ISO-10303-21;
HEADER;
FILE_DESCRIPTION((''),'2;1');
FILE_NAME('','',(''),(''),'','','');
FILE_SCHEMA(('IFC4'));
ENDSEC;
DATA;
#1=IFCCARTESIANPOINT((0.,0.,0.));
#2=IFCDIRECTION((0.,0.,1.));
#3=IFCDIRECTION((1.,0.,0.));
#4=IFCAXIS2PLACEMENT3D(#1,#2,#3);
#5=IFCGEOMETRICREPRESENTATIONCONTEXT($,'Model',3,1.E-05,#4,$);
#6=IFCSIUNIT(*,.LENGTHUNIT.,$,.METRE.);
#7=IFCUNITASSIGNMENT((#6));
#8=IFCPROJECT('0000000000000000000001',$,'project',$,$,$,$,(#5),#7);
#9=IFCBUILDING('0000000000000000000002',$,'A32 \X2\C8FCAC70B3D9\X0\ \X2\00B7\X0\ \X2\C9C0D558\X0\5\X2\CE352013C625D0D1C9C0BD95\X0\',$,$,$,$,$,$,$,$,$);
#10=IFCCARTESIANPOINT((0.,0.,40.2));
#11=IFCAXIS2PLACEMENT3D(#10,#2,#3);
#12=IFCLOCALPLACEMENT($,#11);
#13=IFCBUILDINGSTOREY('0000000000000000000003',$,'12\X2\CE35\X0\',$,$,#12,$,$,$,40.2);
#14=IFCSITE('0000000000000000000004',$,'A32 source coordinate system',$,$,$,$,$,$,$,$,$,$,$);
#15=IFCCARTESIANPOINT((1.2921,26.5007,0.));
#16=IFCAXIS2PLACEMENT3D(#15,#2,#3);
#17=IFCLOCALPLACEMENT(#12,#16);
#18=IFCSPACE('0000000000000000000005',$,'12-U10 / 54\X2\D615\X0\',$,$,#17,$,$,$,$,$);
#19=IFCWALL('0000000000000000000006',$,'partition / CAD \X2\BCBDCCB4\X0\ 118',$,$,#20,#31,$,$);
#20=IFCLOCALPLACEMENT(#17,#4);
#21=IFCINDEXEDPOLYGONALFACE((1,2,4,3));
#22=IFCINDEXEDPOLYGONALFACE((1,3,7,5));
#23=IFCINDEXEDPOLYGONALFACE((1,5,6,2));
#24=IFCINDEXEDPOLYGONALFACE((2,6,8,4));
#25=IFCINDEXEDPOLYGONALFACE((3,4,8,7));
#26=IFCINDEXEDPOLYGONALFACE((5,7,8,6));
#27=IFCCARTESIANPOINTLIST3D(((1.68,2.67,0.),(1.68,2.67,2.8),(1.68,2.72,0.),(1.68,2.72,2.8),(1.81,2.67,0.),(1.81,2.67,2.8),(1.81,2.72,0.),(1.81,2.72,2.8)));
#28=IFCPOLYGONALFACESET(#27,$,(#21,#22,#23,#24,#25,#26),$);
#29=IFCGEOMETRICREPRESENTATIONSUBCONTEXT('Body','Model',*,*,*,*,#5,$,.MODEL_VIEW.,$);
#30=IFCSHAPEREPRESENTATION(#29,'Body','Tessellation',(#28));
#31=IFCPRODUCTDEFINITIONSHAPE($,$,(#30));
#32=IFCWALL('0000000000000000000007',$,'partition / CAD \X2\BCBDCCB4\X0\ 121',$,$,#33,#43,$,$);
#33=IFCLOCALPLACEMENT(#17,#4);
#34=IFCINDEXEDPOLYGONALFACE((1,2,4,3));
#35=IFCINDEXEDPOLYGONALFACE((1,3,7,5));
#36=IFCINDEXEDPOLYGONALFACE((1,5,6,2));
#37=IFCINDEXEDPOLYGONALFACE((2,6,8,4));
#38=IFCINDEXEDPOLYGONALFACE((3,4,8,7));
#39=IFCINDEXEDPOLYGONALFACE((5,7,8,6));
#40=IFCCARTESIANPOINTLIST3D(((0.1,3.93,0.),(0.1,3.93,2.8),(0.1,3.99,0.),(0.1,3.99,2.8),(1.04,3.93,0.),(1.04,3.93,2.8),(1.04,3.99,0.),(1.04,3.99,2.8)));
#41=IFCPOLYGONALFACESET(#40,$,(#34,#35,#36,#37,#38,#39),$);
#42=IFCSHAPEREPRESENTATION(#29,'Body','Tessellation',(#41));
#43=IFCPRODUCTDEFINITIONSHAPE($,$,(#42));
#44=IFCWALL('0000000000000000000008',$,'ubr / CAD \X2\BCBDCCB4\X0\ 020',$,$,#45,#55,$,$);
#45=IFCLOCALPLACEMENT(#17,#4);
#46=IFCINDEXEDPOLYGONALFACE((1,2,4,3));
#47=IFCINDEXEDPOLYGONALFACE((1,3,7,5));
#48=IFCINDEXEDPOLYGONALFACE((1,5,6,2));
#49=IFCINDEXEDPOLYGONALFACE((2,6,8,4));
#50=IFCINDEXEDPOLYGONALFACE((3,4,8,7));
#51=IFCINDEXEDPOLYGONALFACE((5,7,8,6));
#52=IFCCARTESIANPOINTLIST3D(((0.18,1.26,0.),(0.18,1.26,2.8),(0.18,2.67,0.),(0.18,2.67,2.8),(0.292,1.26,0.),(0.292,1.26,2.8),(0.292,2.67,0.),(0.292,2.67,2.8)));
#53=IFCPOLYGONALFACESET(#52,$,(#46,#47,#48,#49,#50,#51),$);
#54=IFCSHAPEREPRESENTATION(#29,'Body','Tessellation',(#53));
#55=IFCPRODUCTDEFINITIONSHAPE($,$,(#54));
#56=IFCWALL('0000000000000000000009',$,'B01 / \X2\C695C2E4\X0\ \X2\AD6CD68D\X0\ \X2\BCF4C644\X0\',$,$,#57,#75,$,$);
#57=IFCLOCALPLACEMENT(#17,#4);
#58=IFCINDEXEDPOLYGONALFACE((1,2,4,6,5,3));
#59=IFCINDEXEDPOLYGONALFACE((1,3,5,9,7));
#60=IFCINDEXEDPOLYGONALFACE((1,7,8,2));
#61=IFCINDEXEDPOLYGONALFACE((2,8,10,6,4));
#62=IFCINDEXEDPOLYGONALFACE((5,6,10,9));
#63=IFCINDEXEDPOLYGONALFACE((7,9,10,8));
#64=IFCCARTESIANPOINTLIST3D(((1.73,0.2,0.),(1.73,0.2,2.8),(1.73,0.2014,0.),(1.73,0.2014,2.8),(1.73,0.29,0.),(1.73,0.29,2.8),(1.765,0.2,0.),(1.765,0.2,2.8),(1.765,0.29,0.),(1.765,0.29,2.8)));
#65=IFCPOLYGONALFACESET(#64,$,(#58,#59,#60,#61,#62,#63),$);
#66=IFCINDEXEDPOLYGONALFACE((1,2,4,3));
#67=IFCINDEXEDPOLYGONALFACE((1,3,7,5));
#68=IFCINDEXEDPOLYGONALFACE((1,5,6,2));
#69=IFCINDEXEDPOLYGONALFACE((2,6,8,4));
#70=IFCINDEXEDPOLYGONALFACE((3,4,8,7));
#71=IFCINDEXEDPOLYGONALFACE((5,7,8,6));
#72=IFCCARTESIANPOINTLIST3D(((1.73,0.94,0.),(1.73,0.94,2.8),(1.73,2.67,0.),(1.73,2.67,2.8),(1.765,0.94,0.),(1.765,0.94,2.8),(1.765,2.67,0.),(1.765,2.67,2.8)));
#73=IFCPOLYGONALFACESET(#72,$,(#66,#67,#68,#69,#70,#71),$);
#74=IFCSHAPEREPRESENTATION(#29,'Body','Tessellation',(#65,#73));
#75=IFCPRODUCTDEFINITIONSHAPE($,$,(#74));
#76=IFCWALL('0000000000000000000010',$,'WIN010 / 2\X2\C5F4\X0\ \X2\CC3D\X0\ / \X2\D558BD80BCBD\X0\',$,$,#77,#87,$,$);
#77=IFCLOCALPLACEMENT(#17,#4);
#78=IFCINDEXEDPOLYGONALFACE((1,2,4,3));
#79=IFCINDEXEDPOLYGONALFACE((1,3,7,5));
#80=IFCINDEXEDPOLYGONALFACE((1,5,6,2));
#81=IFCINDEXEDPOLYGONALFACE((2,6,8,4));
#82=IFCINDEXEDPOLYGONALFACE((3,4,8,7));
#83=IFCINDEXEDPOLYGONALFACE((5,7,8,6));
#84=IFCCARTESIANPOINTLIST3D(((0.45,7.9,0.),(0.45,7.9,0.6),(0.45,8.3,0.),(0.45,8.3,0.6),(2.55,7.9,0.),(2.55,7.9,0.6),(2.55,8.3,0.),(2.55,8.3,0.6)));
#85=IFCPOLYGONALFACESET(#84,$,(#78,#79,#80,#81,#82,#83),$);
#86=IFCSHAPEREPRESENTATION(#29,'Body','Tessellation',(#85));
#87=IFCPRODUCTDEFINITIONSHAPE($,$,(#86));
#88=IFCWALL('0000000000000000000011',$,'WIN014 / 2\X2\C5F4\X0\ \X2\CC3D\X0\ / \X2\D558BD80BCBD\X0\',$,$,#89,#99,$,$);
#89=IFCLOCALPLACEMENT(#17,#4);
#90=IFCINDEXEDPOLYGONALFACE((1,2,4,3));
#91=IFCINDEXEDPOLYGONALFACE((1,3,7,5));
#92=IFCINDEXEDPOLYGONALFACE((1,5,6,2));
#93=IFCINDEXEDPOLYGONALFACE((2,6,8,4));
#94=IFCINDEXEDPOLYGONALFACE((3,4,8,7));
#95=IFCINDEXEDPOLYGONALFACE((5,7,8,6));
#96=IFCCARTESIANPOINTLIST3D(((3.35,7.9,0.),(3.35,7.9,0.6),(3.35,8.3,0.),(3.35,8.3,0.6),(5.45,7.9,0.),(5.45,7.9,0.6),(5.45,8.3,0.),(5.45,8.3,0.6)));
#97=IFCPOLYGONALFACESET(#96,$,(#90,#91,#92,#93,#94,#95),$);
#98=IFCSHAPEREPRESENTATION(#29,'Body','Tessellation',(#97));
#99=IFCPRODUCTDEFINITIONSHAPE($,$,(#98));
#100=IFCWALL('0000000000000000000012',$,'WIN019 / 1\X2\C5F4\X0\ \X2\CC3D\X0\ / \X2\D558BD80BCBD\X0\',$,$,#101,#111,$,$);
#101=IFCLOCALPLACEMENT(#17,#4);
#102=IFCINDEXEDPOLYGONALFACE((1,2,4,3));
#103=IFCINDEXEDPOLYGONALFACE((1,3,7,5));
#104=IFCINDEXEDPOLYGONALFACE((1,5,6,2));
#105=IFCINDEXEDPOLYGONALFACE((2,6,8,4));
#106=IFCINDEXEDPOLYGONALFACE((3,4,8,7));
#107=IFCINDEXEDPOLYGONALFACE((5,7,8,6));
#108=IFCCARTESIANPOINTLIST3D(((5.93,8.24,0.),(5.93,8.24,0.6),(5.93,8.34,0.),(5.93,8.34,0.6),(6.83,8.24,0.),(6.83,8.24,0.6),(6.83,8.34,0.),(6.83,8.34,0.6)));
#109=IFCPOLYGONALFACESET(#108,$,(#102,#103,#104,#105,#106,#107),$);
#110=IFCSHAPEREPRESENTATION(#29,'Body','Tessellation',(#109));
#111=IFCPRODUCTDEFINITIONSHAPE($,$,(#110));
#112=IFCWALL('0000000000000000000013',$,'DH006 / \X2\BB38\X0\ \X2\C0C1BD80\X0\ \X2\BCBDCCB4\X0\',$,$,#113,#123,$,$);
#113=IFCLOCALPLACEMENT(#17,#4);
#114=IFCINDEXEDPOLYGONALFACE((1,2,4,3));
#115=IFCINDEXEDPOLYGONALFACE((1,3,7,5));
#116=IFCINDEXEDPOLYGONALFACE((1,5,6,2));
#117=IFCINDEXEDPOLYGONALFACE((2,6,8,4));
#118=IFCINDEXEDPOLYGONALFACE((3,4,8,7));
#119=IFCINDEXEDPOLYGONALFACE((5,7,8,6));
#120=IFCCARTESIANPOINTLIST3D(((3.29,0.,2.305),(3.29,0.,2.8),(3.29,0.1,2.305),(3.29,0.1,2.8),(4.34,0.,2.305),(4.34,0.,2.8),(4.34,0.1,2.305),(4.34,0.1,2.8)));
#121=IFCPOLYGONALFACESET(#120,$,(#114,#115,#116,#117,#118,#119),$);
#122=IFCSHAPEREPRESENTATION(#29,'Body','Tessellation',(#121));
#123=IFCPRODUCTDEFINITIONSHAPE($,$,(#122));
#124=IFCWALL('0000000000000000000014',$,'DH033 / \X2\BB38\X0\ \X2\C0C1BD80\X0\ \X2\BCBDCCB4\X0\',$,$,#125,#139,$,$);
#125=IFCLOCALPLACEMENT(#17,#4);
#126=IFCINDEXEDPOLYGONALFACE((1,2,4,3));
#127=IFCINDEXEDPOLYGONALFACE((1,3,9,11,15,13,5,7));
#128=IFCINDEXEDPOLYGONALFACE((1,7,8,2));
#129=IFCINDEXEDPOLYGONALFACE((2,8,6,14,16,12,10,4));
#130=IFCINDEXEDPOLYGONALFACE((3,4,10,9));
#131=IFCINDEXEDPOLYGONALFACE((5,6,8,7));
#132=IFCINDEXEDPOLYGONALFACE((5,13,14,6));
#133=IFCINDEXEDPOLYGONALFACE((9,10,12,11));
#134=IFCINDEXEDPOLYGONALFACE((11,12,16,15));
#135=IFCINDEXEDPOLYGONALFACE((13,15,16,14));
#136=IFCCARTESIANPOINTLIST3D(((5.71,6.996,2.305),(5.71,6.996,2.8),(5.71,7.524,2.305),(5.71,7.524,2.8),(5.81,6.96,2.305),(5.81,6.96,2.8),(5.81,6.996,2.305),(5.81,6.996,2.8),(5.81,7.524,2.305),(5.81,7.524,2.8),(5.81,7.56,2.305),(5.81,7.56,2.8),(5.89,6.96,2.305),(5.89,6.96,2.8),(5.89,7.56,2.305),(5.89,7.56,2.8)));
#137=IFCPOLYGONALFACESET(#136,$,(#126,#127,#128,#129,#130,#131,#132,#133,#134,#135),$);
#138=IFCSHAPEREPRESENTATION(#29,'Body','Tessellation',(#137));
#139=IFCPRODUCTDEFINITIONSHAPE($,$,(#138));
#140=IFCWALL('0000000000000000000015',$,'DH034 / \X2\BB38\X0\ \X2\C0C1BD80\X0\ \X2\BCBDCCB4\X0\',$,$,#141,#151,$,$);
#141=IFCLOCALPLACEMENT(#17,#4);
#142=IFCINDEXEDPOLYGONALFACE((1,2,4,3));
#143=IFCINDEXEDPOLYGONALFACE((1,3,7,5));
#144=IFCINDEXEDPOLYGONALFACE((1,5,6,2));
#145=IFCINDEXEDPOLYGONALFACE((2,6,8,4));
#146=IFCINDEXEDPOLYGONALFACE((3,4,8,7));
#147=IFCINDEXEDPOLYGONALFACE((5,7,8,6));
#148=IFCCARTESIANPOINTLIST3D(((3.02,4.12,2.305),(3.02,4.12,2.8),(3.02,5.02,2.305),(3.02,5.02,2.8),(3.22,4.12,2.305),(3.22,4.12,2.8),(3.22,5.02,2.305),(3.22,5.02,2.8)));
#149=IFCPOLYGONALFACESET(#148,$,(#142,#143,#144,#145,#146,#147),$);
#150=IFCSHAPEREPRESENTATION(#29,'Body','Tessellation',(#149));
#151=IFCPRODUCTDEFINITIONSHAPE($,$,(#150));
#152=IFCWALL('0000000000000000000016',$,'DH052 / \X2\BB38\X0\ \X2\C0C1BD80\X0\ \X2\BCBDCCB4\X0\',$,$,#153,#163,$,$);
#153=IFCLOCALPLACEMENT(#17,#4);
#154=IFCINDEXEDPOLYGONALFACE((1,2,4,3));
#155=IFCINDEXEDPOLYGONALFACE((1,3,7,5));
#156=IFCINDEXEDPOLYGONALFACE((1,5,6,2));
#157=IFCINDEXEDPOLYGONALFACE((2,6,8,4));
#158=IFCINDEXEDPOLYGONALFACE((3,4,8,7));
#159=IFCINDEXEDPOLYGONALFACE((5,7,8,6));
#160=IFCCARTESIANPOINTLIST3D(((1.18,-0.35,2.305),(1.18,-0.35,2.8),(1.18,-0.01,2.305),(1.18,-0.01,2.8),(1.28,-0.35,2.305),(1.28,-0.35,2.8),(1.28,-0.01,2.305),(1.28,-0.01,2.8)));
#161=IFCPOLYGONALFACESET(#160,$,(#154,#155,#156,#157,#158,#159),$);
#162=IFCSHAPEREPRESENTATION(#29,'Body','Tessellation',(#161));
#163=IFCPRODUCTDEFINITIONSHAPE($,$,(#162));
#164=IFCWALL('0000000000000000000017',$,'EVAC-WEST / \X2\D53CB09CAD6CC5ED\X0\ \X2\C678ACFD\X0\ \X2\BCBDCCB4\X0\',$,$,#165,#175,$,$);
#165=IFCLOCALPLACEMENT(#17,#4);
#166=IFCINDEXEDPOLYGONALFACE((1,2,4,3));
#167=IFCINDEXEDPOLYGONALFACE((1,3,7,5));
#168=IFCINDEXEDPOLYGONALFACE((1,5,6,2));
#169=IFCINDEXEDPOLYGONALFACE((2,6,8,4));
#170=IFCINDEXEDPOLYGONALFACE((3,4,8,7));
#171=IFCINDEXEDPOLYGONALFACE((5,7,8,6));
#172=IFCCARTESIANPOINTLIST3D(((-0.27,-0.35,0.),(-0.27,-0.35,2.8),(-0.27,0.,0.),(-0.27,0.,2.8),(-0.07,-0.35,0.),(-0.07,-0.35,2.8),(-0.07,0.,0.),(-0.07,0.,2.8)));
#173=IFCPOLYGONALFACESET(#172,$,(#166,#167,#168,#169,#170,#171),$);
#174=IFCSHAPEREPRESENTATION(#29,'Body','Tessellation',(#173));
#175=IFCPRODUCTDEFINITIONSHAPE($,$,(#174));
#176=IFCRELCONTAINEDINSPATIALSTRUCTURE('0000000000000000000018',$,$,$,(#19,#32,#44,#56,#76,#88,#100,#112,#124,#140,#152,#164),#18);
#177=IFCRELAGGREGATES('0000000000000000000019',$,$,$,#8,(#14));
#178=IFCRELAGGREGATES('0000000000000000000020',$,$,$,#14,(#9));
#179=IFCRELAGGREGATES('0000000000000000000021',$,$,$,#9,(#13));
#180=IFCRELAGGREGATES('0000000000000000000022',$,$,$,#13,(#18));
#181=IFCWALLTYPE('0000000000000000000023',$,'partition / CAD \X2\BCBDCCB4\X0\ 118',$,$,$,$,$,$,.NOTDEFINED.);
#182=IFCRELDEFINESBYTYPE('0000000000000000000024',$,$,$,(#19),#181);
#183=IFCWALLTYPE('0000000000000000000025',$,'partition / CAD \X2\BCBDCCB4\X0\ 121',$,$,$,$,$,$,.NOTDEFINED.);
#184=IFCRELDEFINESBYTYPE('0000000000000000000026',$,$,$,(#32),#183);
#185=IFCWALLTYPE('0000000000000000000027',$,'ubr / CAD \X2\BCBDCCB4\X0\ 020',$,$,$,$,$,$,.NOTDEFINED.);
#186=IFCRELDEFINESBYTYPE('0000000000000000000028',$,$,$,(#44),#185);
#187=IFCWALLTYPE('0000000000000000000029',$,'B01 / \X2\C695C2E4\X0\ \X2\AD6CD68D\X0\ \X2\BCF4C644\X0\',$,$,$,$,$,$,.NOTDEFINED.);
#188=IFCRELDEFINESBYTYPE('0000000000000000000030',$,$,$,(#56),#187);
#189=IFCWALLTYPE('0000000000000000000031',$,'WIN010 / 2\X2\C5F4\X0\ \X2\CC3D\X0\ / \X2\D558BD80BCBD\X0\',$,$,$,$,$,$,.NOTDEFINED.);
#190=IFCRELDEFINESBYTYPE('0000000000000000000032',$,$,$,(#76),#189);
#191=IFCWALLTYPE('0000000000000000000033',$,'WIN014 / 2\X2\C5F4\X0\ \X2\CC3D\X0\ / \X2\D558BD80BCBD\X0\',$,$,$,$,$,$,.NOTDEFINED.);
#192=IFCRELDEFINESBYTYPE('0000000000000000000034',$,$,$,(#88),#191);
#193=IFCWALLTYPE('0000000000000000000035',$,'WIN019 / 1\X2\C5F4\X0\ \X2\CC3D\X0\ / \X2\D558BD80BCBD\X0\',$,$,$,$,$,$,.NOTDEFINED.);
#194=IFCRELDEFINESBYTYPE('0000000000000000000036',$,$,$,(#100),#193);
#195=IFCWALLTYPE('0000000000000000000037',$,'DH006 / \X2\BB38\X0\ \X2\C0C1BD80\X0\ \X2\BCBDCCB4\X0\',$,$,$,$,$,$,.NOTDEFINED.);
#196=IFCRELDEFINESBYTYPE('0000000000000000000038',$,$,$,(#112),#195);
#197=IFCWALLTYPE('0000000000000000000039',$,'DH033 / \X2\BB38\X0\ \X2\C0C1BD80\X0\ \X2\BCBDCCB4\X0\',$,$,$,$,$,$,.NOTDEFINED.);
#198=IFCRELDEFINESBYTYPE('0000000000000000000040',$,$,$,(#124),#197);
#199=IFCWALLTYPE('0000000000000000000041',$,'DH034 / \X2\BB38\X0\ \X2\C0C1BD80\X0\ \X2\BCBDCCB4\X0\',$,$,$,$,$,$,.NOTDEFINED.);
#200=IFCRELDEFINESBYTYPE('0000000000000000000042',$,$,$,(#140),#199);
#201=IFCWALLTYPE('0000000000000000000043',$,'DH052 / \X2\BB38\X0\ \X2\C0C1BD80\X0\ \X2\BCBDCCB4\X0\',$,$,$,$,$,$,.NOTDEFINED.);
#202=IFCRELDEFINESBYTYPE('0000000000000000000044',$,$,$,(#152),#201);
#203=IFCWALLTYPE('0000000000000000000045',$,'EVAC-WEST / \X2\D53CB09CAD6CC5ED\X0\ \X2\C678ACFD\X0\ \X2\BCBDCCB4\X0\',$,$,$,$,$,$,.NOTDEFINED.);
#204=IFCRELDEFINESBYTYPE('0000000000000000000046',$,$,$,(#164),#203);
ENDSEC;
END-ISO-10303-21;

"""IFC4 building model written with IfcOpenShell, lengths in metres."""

from ifc_helpers import new_model, si_unit, frame, origin, origin_with_axes, place, context, subcontext, project, spatial, polyline, outline, extrude, source, transform, mapped, type_object, type_shapes, element, save


model = new_model("IFC4")

# Units and contexts
model_context = context("Model", 3, precision=1e-05, world=origin_with_axes())
body_context = subcontext(model_context, "Body", "Model", "MODEL_VIEW")
ifc_project = project(units=[si_unit("LENGTHUNIT", "METRE")], contexts=[model_context])

# Site, building, storey, space
site = spatial("IfcSite", under=ifc_project, Name="A32 source coordinate system")
building = spatial("IfcBuilding", under=site, Name="A32 주거동 · 지하5층–옥탑지붕")
storey_placement = place(None, frame((0.0, 0.0, 40.2), z_axis=(0.0, 0.0, 1.0), x_axis=(1.0, 0.0, 0.0)))
storey = spatial("IfcBuildingStorey", under=building, at=storey_placement, Name="12층", Elevation=40.2)
space_placement = place(storey_placement, frame((1.2921, 26.5007, 0.0), z_axis=(0.0, 0.0, 1.0), x_axis=(1.0, 0.0, 0.0)))
space = spatial("IfcSpace", under=storey, at=space_placement, Name="12-U10 / 54형")

# Walls
wall_type_1 = type_object("IfcWallType", Name="partition / CAD 벽체 118", PredefinedType="NOTDEFINED")
shared_shape_1 = source(origin(), body_context, "Body", "SweptSolid", [
    extrude(outline(polyline([(1.81, 2.67), (1.68, 2.67), (1.68, 2.72), (1.81, 2.72), (1.81, 2.67)])), origin(), (0.0, 0.0, 1.0), 2.8),
])
type_shapes(wall_type_1, [shared_shape_1])
wall_1_placement = place(space_placement, origin_with_axes())
element("IfcWall", 1, at=wall_1_placement, inside=space, type_object=wall_type_1, Name="partition / CAD 벽체 118", context=body_context, shape_type="MappedRepresentation", body=[
    mapped(shared_shape_1, transform((0.0, 0.0, 0.0), scale=1.0)),
])
wall_type_2 = type_object("IfcWallType", Name="partition / CAD 벽체 121", PredefinedType="NOTDEFINED")
shared_shape_2 = source(origin(), body_context, "Body", "SweptSolid", [
    extrude(outline(polyline([(0.1, 3.99), (1.04, 3.99), (1.04, 3.93), (0.1, 3.93), (0.1, 3.99)])), origin(), (0.0, 0.0, 1.0), 2.8),
])
type_shapes(wall_type_2, [shared_shape_2])
wall_2_placement = place(space_placement, origin_with_axes())
element("IfcWall", 2, at=wall_2_placement, inside=space, type_object=wall_type_2, Name="partition / CAD 벽체 121", context=body_context, shape_type="MappedRepresentation", body=[
    mapped(shared_shape_2, transform((0.0, 0.0, 0.0), scale=1.0)),
])
wall_type_3 = type_object("IfcWallType", Name="ubr / CAD 벽체 020", PredefinedType="NOTDEFINED")
shared_shape_3 = source(origin(), body_context, "Body", "SweptSolid", [
    extrude(outline(polyline([(0.18, 1.26), (0.18, 2.67), (0.292, 2.67), (0.292, 1.26), (0.18, 1.26)])), origin(), (0.0, 0.0, 1.0), 2.8),
])
type_shapes(wall_type_3, [shared_shape_3])
wall_3_placement = place(space_placement, origin_with_axes())
element("IfcWall", 3, at=wall_3_placement, inside=space, type_object=wall_type_3, Name="ubr / CAD 벽체 020", context=body_context, shape_type="MappedRepresentation", body=[
    mapped(shared_shape_3, transform((0.0, 0.0, 0.0), scale=1.0)),
])
wall_type_4 = type_object("IfcWallType", Name="B01 / 욕실 구획 보완", PredefinedType="NOTDEFINED")
shared_shape_4 = source(origin(), body_context, "Body", "SweptSolid", [
    extrude(outline(polyline([(1.765, 0.2), (1.73, 0.2), (1.73, 0.2014), (1.73, 0.29), (1.765, 0.29), (1.765, 0.2)])), origin(), (0.0, 0.0, 1.0), 2.8),
    extrude(outline(polyline([(1.765, 2.67), (1.765, 0.94), (1.73, 0.94), (1.73, 2.67), (1.765, 2.67)])), origin(), (0.0, 0.0, 1.0), 2.8),
])
type_shapes(wall_type_4, [shared_shape_4])
wall_4_placement = place(space_placement, origin_with_axes())
element("IfcWall", 4, at=wall_4_placement, inside=space, type_object=wall_type_4, Name="B01 / 욕실 구획 보완", context=body_context, shape_type="MappedRepresentation", body=[
    mapped(shared_shape_4, transform((0.0, 0.0, 0.0), scale=1.0)),
])
wall_type_5 = type_object("IfcWallType", Name="WIN010 / 2열 창 / 하부벽", PredefinedType="NOTDEFINED")
shared_shape_5 = source(origin(), body_context, "Body", "SweptSolid", [
    extrude(outline(polyline([(2.55, 8.3), (2.55, 7.9), (0.45, 7.9), (0.45, 8.3), (2.55, 8.3)])), origin(), (0.0, 0.0, 1.0), 0.6),
])
type_shapes(wall_type_5, [shared_shape_5])
wall_5_placement = place(space_placement, origin_with_axes())
element("IfcWall", 5, at=wall_5_placement, inside=space, type_object=wall_type_5, Name="WIN010 / 2열 창 / 하부벽", context=body_context, shape_type="MappedRepresentation", body=[
    mapped(shared_shape_5, transform((0.0, 0.0, 0.0), scale=1.0)),
])
wall_type_6 = type_object("IfcWallType", Name="WIN014 / 2열 창 / 하부벽", PredefinedType="NOTDEFINED")
shared_shape_6 = source(origin(), body_context, "Body", "SweptSolid", [
    extrude(outline(polyline([(5.45, 8.3), (5.45, 7.9), (3.35, 7.9), (3.35, 8.3), (5.45, 8.3)])), origin(), (0.0, 0.0, 1.0), 0.6),
])
type_shapes(wall_type_6, [shared_shape_6])
wall_6_placement = place(space_placement, origin_with_axes())
element("IfcWall", 6, at=wall_6_placement, inside=space, type_object=wall_type_6, Name="WIN014 / 2열 창 / 하부벽", context=body_context, shape_type="MappedRepresentation", body=[
    mapped(shared_shape_6, transform((0.0, 0.0, 0.0), scale=1.0)),
])
wall_type_7 = type_object("IfcWallType", Name="WIN019 / 1열 창 / 하부벽", PredefinedType="NOTDEFINED")
shared_shape_7 = source(origin(), body_context, "Body", "SweptSolid", [
    extrude(outline(polyline([(6.83, 8.34), (6.83, 8.24), (5.93, 8.24), (5.93, 8.34), (6.83, 8.34)])), origin(), (0.0, 0.0, 1.0), 0.6),
])
type_shapes(wall_type_7, [shared_shape_7])
wall_7_placement = place(space_placement, origin_with_axes())
element("IfcWall", 7, at=wall_7_placement, inside=space, type_object=wall_type_7, Name="WIN019 / 1열 창 / 하부벽", context=body_context, shape_type="MappedRepresentation", body=[
    mapped(shared_shape_7, transform((0.0, 0.0, 0.0), scale=1.0)),
])
wall_type_8 = type_object("IfcWallType", Name="DH006 / 문 상부 벽체", PredefinedType="NOTDEFINED")
shared_shape_8 = source(origin(), body_context, "Body", "SweptSolid", [
    extrude(outline(polyline([(4.34, 0.0), (3.29, 0.0), (3.29, 0.1), (4.34, 0.1), (4.34, 0.0)])), frame((0.0, 0.0, 2.305)), (0.0, 0.0, 1.0), 0.495),
])
type_shapes(wall_type_8, [shared_shape_8])
wall_8_placement = place(space_placement, origin_with_axes())
element("IfcWall", 8, at=wall_8_placement, inside=space, type_object=wall_type_8, Name="DH006 / 문 상부 벽체", context=body_context, shape_type="MappedRepresentation", body=[
    mapped(shared_shape_8, transform((0.0, 0.0, 0.0), scale=1.0)),
])
wall_type_9 = type_object("IfcWallType", Name="DH033 / 문 상부 벽체", PredefinedType="NOTDEFINED")
shared_shape_9 = source(origin(), body_context, "Body", "SweptSolid", [
    extrude(outline(polyline([(5.81, 6.996), (5.71, 6.996), (5.71, 7.524), (5.81, 7.524), (5.81, 7.56), (5.89, 7.56), (5.89, 6.96), (5.81, 6.96), (5.81, 6.996)])), frame((0.0, 0.0, 2.305)), (0.0, 0.0, 1.0), 0.495),
])
type_shapes(wall_type_9, [shared_shape_9])
wall_9_placement = place(space_placement, origin_with_axes())
element("IfcWall", 9, at=wall_9_placement, inside=space, type_object=wall_type_9, Name="DH033 / 문 상부 벽체", context=body_context, shape_type="MappedRepresentation", body=[
    mapped(shared_shape_9, transform((0.0, 0.0, 0.0), scale=1.0)),
])
wall_type_10 = type_object("IfcWallType", Name="DH034 / 문 상부 벽체", PredefinedType="NOTDEFINED")
shared_shape_10 = source(origin(), body_context, "Body", "SweptSolid", [
    extrude(outline(polyline([(3.22, 4.12), (3.02, 4.12), (3.02, 5.02), (3.22, 5.02), (3.22, 4.12)])), frame((0.0, 0.0, 2.305)), (0.0, 0.0, 1.0), 0.495),
])
type_shapes(wall_type_10, [shared_shape_10])
wall_10_placement = place(space_placement, origin_with_axes())
element("IfcWall", 10, at=wall_10_placement, inside=space, type_object=wall_type_10, Name="DH034 / 문 상부 벽체", context=body_context, shape_type="MappedRepresentation", body=[
    mapped(shared_shape_10, transform((0.0, 0.0, 0.0), scale=1.0)),
])
wall_type_11 = type_object("IfcWallType", Name="DH052 / 문 상부 벽체", PredefinedType="NOTDEFINED")
shared_shape_11 = source(origin(), body_context, "Body", "SweptSolid", [
    extrude(outline(polyline([(1.28, -0.35), (1.18, -0.35), (1.18, -0.01), (1.28, -0.01), (1.28, -0.35)])), frame((0.0, 0.0, 2.305)), (0.0, 0.0, 1.0), 0.495),
])
type_shapes(wall_type_11, [shared_shape_11])
wall_11_placement = place(space_placement, origin_with_axes())
element("IfcWall", 11, at=wall_11_placement, inside=space, type_object=wall_type_11, Name="DH052 / 문 상부 벽체", context=body_context, shape_type="MappedRepresentation", body=[
    mapped(shared_shape_11, transform((0.0, 0.0, 0.0), scale=1.0)),
])
wall_type_12 = type_object("IfcWallType", Name="EVAC-WEST / 피난구역 외곽 벽체", PredefinedType="NOTDEFINED")
shared_shape_12 = source(origin(), body_context, "Body", "SweptSolid", [
    extrude(outline(polyline([(-0.07, 0.0), (-0.07, -0.35), (-0.27, -0.35), (-0.27, 0.0), (-0.07, 0.0)])), origin(), (0.0, 0.0, 1.0), 2.8),
])
type_shapes(wall_type_12, [shared_shape_12])
wall_12_placement = place(space_placement, origin_with_axes())
element("IfcWall", 12, at=wall_12_placement, inside=space, type_object=wall_type_12, Name="EVAC-WEST / 피난구역 외곽 벽체", context=body_context, shape_type="MappedRepresentation", body=[
    mapped(shared_shape_12, transform((0.0, 0.0, 0.0), scale=1.0)),
])

save(model, "model.ifc")
